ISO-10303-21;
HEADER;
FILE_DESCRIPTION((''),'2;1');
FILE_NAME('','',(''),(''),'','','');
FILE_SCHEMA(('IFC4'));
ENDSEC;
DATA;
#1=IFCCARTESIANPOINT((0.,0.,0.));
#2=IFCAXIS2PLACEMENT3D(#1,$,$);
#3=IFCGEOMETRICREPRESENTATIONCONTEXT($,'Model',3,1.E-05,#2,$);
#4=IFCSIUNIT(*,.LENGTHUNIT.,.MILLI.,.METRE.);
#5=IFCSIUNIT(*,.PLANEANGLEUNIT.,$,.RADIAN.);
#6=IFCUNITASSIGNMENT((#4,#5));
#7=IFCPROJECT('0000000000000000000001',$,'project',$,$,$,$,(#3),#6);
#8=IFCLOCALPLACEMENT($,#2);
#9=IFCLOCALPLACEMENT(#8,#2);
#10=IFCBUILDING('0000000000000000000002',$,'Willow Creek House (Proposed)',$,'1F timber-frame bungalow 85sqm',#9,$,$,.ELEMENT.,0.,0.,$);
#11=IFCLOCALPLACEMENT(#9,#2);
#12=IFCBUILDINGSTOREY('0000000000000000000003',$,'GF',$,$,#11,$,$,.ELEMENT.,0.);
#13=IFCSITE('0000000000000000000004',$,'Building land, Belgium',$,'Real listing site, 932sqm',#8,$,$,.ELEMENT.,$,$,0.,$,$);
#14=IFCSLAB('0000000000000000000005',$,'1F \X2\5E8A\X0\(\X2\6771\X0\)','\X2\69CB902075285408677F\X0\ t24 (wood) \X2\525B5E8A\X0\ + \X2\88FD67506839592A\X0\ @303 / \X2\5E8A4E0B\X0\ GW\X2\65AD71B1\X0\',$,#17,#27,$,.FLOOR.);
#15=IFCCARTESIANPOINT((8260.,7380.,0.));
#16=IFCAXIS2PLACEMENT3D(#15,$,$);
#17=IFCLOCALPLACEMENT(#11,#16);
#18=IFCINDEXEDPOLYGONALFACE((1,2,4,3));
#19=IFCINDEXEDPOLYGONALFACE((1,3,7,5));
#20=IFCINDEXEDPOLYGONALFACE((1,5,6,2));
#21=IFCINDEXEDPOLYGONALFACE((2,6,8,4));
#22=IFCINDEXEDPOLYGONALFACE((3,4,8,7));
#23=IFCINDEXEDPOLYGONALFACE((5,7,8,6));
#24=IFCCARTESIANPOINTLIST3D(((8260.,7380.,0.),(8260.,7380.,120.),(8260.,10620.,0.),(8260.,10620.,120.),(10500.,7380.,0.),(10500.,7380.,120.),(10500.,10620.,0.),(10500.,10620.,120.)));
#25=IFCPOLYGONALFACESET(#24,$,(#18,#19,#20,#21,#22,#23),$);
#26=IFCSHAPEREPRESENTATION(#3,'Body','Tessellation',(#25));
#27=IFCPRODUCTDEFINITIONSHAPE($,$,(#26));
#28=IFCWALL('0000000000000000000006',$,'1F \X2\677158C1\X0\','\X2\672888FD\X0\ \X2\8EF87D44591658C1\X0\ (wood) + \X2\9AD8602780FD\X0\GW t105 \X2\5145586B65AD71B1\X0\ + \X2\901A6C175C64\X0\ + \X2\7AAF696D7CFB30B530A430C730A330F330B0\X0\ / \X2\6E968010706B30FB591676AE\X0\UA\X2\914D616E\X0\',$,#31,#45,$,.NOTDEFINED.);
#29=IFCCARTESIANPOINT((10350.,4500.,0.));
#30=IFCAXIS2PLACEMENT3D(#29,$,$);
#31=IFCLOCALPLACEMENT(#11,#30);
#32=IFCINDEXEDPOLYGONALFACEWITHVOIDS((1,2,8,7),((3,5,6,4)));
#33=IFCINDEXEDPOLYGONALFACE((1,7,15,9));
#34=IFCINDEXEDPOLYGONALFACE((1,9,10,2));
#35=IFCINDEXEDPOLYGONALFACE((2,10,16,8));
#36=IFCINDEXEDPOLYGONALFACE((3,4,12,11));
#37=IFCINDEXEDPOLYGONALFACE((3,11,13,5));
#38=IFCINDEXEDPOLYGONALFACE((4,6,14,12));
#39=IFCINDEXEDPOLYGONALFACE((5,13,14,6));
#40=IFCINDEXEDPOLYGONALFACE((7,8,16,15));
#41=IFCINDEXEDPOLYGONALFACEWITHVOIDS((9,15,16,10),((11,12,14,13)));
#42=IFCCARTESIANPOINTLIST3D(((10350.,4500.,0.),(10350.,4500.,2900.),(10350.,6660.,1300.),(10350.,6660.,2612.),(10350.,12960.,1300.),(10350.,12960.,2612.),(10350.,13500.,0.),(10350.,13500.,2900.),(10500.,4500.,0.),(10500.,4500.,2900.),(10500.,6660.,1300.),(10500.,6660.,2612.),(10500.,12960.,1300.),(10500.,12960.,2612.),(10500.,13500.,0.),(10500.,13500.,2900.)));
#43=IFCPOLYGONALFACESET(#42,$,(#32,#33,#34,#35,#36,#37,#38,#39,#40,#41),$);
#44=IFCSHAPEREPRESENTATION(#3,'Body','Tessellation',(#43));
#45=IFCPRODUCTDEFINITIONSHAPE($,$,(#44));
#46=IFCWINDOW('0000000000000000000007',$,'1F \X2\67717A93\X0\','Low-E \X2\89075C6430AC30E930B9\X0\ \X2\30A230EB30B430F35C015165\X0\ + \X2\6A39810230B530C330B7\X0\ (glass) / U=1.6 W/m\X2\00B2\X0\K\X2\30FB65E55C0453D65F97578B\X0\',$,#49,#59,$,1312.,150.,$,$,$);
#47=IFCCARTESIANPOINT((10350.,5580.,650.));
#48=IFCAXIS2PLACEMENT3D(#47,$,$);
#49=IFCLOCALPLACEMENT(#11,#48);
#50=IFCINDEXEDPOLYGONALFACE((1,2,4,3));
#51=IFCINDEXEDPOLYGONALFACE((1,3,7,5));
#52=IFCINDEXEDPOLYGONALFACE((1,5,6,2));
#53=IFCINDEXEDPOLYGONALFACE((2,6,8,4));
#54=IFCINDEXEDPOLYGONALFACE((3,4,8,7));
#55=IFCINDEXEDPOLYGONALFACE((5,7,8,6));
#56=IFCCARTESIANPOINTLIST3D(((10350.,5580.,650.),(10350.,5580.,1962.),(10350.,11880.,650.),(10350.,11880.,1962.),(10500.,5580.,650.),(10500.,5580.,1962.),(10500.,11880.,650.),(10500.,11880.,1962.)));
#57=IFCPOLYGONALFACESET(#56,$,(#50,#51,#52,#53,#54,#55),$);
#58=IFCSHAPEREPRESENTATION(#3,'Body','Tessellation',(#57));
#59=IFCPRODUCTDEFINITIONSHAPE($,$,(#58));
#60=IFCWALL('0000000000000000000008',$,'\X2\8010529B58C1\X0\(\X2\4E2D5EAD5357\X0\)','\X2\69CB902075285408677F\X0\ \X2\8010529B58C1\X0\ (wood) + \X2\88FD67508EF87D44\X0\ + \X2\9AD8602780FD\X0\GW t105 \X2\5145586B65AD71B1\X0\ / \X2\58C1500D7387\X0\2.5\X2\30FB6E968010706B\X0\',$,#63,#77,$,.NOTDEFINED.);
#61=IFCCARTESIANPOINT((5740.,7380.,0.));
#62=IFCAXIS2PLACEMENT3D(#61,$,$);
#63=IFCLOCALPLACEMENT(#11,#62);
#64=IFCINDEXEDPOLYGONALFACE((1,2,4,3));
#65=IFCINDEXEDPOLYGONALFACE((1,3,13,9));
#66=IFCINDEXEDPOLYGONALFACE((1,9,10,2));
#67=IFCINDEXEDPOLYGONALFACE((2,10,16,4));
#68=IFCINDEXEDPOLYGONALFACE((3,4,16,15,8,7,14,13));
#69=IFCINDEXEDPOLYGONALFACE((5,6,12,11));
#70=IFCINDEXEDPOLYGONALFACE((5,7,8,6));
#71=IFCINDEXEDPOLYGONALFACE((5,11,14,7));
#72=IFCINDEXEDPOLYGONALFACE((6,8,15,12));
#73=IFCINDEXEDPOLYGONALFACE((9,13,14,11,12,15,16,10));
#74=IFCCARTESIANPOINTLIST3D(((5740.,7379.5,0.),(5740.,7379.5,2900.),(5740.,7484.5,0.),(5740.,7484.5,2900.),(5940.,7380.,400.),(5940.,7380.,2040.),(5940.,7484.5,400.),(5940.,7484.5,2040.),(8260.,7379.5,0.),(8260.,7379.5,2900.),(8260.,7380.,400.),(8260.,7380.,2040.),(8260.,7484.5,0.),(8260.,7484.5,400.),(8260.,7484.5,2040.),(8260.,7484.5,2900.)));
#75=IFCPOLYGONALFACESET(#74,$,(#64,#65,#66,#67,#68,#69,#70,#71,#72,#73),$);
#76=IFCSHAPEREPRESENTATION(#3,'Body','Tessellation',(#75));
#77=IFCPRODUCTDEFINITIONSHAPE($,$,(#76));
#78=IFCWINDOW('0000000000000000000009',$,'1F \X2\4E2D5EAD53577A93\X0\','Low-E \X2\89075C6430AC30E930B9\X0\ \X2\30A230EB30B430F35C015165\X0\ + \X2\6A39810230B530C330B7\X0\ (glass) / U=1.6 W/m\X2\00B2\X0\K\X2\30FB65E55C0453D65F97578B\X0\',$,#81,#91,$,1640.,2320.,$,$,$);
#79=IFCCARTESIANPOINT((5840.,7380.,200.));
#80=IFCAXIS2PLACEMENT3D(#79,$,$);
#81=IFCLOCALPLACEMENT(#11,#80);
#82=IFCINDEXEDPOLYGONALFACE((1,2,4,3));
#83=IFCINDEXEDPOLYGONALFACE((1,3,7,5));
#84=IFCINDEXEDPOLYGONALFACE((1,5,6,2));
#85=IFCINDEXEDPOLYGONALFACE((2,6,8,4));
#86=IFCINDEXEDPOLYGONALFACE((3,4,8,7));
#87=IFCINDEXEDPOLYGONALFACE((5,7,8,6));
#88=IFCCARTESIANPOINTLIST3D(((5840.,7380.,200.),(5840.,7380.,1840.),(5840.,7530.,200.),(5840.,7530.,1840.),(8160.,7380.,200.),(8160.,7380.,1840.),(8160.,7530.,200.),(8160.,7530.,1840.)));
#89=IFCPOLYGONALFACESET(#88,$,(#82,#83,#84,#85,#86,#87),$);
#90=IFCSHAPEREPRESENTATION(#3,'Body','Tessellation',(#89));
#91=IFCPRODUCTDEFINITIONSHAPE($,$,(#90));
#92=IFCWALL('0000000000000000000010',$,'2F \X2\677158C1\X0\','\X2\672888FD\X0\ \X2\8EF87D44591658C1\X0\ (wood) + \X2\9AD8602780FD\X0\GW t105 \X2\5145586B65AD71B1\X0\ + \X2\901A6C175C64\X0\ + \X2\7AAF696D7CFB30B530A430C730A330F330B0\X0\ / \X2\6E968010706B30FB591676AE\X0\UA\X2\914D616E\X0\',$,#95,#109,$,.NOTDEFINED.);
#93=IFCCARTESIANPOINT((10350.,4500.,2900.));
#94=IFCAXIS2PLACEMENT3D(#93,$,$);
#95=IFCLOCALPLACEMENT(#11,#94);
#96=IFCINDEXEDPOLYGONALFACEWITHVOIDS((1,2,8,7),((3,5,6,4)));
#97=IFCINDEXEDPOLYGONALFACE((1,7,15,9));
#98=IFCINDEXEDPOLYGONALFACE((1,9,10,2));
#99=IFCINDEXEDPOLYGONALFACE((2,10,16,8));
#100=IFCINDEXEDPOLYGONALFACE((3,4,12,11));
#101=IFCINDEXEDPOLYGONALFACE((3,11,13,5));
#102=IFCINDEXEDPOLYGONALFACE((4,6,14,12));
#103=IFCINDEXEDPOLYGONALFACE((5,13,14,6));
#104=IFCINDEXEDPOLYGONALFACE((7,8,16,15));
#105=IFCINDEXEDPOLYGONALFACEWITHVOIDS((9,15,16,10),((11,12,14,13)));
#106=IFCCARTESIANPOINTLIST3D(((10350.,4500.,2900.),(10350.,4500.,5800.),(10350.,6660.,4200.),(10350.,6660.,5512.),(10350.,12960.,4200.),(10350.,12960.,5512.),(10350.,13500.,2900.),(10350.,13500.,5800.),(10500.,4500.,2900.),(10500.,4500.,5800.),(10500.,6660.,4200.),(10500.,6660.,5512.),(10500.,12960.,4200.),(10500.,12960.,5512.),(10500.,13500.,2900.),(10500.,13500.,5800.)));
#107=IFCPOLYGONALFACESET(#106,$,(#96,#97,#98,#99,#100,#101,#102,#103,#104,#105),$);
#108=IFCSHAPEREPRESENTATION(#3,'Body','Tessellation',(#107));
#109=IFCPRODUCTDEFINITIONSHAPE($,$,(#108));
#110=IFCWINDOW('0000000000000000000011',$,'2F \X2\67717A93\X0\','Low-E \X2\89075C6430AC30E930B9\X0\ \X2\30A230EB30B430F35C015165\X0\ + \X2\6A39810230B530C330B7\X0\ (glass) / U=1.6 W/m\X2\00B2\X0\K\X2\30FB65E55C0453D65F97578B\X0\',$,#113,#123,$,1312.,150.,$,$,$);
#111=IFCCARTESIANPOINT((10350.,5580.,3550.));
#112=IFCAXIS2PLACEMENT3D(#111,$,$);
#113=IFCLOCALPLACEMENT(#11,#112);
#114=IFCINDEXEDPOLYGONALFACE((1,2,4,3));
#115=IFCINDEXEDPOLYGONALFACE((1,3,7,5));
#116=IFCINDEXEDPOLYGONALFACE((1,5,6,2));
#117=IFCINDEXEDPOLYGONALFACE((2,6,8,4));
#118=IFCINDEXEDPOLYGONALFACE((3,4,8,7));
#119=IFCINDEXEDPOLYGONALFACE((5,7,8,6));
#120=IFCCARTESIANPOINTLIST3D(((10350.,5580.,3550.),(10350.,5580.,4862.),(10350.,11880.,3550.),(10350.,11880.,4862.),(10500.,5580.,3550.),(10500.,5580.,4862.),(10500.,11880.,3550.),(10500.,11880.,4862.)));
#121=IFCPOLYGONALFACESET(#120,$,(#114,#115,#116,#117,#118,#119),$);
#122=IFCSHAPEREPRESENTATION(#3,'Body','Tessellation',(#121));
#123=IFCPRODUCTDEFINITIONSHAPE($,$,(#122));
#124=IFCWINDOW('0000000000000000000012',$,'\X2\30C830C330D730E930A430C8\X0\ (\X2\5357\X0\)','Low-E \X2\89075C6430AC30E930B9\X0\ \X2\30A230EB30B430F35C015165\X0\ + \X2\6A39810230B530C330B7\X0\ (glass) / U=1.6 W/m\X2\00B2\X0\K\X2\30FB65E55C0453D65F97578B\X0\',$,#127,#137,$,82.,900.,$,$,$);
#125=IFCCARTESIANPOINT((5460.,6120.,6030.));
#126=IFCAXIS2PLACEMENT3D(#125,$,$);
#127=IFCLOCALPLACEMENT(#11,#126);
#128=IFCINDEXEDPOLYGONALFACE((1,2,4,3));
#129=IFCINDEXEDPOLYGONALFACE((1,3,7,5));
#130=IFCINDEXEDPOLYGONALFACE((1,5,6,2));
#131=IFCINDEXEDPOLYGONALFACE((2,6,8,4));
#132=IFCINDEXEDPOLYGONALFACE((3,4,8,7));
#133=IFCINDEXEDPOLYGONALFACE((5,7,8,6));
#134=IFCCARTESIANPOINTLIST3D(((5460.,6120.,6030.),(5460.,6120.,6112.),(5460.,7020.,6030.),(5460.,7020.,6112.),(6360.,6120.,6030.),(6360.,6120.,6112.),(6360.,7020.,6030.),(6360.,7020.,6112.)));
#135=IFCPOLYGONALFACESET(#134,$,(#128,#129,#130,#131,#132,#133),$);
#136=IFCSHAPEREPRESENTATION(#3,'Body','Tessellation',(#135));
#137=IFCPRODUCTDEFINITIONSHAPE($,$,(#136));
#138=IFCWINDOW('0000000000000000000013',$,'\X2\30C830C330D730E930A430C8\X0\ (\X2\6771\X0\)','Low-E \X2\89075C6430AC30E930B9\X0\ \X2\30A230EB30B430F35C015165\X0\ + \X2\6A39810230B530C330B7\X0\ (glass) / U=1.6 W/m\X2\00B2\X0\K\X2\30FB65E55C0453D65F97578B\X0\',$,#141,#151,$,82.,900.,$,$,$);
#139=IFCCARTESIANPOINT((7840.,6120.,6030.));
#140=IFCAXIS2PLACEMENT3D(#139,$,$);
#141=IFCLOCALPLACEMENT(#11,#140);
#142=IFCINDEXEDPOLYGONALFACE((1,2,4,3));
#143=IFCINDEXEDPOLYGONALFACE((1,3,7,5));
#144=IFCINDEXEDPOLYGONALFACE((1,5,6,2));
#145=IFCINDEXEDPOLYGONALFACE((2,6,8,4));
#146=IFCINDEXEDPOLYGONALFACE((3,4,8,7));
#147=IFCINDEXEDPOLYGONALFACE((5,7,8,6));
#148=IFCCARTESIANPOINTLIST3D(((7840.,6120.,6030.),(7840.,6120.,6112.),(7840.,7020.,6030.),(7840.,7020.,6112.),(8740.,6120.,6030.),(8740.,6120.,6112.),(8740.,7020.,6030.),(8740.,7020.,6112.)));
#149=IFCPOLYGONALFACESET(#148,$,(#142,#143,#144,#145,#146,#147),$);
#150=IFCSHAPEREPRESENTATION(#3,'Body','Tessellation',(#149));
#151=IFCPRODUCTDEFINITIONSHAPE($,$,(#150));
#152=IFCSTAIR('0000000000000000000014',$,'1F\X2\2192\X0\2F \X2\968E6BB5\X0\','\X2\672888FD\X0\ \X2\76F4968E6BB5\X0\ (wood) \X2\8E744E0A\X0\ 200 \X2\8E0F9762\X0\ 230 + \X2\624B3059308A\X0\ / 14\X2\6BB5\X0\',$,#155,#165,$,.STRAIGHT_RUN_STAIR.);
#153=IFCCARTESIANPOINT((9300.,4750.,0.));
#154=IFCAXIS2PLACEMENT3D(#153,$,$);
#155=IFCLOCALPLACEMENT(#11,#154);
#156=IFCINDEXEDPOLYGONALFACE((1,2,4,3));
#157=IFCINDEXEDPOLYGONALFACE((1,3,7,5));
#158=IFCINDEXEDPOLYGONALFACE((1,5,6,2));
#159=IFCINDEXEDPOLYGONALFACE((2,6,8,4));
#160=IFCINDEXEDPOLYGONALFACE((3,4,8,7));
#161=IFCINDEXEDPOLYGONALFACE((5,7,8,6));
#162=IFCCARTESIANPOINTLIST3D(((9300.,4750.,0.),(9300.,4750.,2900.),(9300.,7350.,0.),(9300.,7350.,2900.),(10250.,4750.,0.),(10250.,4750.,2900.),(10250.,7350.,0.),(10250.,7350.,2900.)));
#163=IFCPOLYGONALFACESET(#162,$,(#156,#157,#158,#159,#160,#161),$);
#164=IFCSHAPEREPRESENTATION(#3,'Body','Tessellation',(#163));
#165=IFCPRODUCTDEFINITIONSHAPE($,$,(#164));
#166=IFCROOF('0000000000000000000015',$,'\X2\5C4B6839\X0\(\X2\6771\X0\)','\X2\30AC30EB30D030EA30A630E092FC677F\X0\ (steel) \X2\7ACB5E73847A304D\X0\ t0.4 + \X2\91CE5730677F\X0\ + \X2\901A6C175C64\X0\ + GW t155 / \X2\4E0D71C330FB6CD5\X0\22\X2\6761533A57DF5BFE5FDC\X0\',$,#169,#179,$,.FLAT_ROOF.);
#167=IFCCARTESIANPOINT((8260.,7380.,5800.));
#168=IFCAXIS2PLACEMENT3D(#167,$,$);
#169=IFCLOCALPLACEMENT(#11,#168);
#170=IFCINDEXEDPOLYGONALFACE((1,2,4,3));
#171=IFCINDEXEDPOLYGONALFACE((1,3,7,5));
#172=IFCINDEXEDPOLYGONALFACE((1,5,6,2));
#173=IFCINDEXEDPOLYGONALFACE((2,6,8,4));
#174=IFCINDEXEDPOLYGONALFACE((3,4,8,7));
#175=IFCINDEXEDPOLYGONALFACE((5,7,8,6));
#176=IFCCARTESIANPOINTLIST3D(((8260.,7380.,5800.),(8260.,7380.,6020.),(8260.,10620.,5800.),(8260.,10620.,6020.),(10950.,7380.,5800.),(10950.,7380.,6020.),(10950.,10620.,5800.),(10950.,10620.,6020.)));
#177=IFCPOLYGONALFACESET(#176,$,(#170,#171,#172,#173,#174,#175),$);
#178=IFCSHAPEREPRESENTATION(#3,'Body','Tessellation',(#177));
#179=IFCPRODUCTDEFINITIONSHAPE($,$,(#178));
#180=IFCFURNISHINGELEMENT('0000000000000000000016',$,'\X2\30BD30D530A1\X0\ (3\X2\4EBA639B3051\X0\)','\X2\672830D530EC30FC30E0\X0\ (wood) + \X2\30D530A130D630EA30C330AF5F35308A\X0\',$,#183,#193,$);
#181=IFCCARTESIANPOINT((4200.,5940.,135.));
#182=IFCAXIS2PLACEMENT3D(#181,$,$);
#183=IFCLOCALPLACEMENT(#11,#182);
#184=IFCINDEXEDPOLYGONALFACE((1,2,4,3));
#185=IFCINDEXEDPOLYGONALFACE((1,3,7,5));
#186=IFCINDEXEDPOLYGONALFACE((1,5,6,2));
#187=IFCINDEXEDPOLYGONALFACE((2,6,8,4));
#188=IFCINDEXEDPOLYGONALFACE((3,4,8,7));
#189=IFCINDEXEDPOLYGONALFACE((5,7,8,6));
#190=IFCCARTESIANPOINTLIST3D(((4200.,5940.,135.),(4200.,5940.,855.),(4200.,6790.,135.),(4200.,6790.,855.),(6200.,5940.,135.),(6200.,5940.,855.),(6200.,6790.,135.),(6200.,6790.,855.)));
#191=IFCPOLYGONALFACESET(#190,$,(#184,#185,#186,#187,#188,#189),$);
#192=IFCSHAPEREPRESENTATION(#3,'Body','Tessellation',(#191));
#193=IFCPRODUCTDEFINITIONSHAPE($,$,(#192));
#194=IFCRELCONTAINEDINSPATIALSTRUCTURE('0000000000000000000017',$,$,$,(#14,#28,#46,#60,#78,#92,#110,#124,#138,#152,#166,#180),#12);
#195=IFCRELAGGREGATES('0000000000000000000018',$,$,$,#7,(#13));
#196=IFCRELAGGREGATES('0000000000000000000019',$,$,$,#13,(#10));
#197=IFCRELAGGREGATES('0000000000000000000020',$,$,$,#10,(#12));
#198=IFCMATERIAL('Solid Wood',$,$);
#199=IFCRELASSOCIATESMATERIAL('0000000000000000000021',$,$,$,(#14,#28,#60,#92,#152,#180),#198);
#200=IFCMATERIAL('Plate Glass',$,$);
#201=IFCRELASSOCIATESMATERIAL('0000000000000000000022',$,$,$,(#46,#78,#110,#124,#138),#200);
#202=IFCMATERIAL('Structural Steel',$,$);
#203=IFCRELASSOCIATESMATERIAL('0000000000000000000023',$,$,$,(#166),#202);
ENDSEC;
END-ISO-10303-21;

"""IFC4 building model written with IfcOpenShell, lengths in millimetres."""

from ifc_helpers import new_model, si_unit, frame, frame_2d, origin, place, context, project, spatial, rectangle, extrude, material, element, fill, save


model = new_model("IFC4")

# Units and contexts
model_context = context("Model", 3, precision=1e-05, world=origin())
ifc_project = project(units=[si_unit("LENGTHUNIT", "METRE", prefix="MILLI"), si_unit("PLANEANGLEUNIT", "RADIAN")], contexts=[model_context])

# Site, building, storey
site_placement = place(None, origin())
site = spatial("IfcSite", under=ifc_project, at=site_placement, Name="Building land, Belgium", ObjectType="Real listing site, 932sqm", CompositionType="ELEMENT", RefElevation=0.0)
building_placement = place(site_placement, origin())
building = spatial("IfcBuilding", under=site, at=building_placement, Name="Willow Creek House (Proposed)", ObjectType="1F timber-frame bungalow 85sqm", CompositionType="ELEMENT", ElevationOfRefHeight=0.0, ElevationOfTerrain=0.0)
storey_placement = place(building_placement, origin())
storey = spatial("IfcBuildingStorey", under=building, at=storey_placement, Name="GF", CompositionType="ELEMENT", Elevation=0.0)

# Slab
ifc_material_1 = material(Name="Solid Wood")
slab_placement = place(storey_placement, frame((8260.0, 7380.0, 0.0)))
element("IfcSlab", 1, at=slab_placement, inside=storey, material=ifc_material_1, Name="1F 床(東)", Description="構造用合板 t24 (wood) 剛床 + 製材根太 @303 / 床下 GW断熱", PredefinedType="FLOOR", context=model_context, shape_type="SweptSolid", body=[
    extrude(rectangle(XDim=2240.0, YDim=3240.0, at=frame_2d((1120.0, 1620.0))), frame((8260.0, 7380.0, 0.0)), (0.0, 0.0, 1.0), 120.0),
])

# Walls, openings, windows
wall_1_placement = place(storey_placement, frame((10350.0, 4500.0, 0.0)))
wall_1 = element("IfcWall", 2, at=wall_1_placement, inside=storey, material=ifc_material_1, Name="1F 東壁", Description="木製 軸組外壁 (wood) + 高性能GW t105 充填断熱 + 通気層 + 窯業系サイディング / 準耐火・外皮UA配慮", PredefinedType="NOTDEFINED", context=model_context, shape_type="SweptSolid", body=[
    extrude(rectangle(XDim=150.0, YDim=9000.0, at=frame_2d((75.0, 4500.0))), frame((10350.0, 4500.0, 0.0)), (0.0, 0.0, 1.0), 2900.0),
])
opening_1_placement = place(storey_placement, frame((10350.0, 5580.0, 650.0)))
opening_1 = element("IfcOpeningElement", 3, at=opening_1_placement, cuts=wall_1, PredefinedType="NOTDEFINED", context=model_context, shape_type="SweptSolid", body=[
    extrude(rectangle(XDim=150.0, YDim=6300.0, at=frame_2d((75.0, 3150.0))), frame((10350.0, 5580.0, 650.0)), (0.0, 0.0, 1.0), 1312.0),
])
ifc_material_2 = material(Name="Plate Glass")
window_1_placement = place(storey_placement, frame((10350.0, 5580.0, 650.0)))
window_1 = element("IfcWindow", 4, at=window_1_placement, inside=storey, material=ifc_material_2, Name="1F 東窓", Description="Low-E 複層ガラス アルゴン封入 + 樹脂サッシ (glass) / U=1.6 W/m²K・日射取得型", OverallHeight=1312.0, OverallWidth=150.0, context=model_context, shape_type="SweptSolid", body=[
    extrude(rectangle(XDim=150.0, YDim=6300.0, at=frame_2d((75.0, 3150.0))), frame((10350.0, 5580.0, 650.0)), (0.0, 0.0, 1.0), 1312.0),
])
fill(opening_1, window_1)
wall_2_placement = place(storey_placement, frame((5740.0, 7380.0, 0.0)))
wall_2 = element("IfcWall", 5, at=wall_2_placement, inside=storey, material=ifc_material_1, Name="耐力壁(中庭南)", Description="構造用合板 耐力壁 (wood) + 製材軸組 + 高性能GW t105 充填断熱 / 壁倍率2.5・準耐火", PredefinedType="NOTDEFINED", context=model_context, shape_type="SweptSolid", body=[
    extrude(rectangle(XDim=2520.0, YDim=105.0, at=frame_2d((1260.0, 52.0))), frame((5740.0, 7380.0, 0.0)), (0.0, 0.0, 1.0), 2900.0),
])
opening_2_placement = place(storey_placement, frame((5840.0, 7380.0, 200.0)))
opening_2 = element("IfcOpeningElement", 6, at=opening_2_placement, cuts=wall_2, PredefinedType="NOTDEFINED", context=model_context, shape_type="SweptSolid", body=[
    extrude(rectangle(XDim=2320.0, YDim=150.0, at=frame_2d((1160.0, 75.0))), frame((5840.0, 7380.0, 200.0)), (0.0, 0.0, 1.0), 1640.0),
])
window_2_placement = place(storey_placement, frame((5840.0, 7380.0, 200.0)))
window_2 = element("IfcWindow", 7, at=window_2_placement, inside=storey, material=ifc_material_2, Name="1F 中庭南窓", Description="Low-E 複層ガラス アルゴン封入 + 樹脂サッシ (glass) / U=1.6 W/m²K・日射取得型", OverallHeight=1640.0, OverallWidth=2320.0, context=model_context, shape_type="SweptSolid", body=[
    extrude(rectangle(XDim=2320.0, YDim=150.0, at=frame_2d((1160.0, 75.0))), frame((5840.0, 7380.0, 200.0)), (0.0, 0.0, 1.0), 1640.0),
])
fill(opening_2, window_2)

# Wall, opening, window
wall_3_placement = place(storey_placement, frame((10350.0, 4500.0, 2900.0)))
wall_3 = element("IfcWall", 8, at=wall_3_placement, inside=storey, material=ifc_material_1, Name="2F 東壁", Description="木製 軸組外壁 (wood) + 高性能GW t105 充填断熱 + 通気層 + 窯業系サイディング / 準耐火・外皮UA配慮", PredefinedType="NOTDEFINED", context=model_context, shape_type="SweptSolid", body=[
    extrude(rectangle(XDim=150.0, YDim=9000.0, at=frame_2d((75.0, 4500.0))), frame((10350.0, 4500.0, 2900.0)), (0.0, 0.0, 1.0), 2900.0),
])
opening_3_placement = place(storey_placement, frame((10350.0, 5580.0, 3550.0)))
opening_3 = element("IfcOpeningElement", 9, at=opening_3_placement, cuts=wall_3, PredefinedType="NOTDEFINED", context=model_context, shape_type="SweptSolid", body=[
    extrude(rectangle(XDim=150.0, YDim=6300.0, at=frame_2d((75.0, 3150.0))), frame((10350.0, 5580.0, 3550.0)), (0.0, 0.0, 1.0), 1312.0),
])
window_3_placement = place(storey_placement, frame((10350.0, 5580.0, 3550.0)))
window_3 = element("IfcWindow", 10, at=window_3_placement, inside=storey, material=ifc_material_2, Name="2F 東窓", Description="Low-E 複層ガラス アルゴン封入 + 樹脂サッシ (glass) / U=1.6 W/m²K・日射取得型", OverallHeight=1312.0, OverallWidth=150.0, context=model_context, shape_type="SweptSolid", body=[
    extrude(rectangle(XDim=150.0, YDim=6300.0, at=frame_2d((75.0, 3150.0))), frame((10350.0, 5580.0, 3550.0)), (0.0, 0.0, 1.0), 1312.0),
])
fill(opening_3, window_3)

# Windows
window_4_placement = place(storey_placement, frame((5460.0, 6120.0, 6030.0)))
element("IfcWindow", 11, at=window_4_placement, inside=storey, material=ifc_material_2, Name="トップライト (南)", Description="Low-E 複層ガラス アルゴン封入 + 樹脂サッシ (glass) / U=1.6 W/m²K・日射取得型", OverallHeight=82.0, OverallWidth=900.0, context=model_context, shape_type="SweptSolid", body=[
    extrude(rectangle(XDim=900.0, YDim=900.0, at=frame_2d((450.0, 450.0))), frame((5460.0, 6120.0, 6030.0)), (0.0, 0.0, 1.0), 82.0),
])
window_5_placement = place(storey_placement, frame((7840.0, 6120.0, 6030.0)))
element("IfcWindow", 12, at=window_5_placement, inside=storey, material=ifc_material_2, Name="トップライト (東)", Description="Low-E 複層ガラス アルゴン封入 + 樹脂サッシ (glass) / U=1.6 W/m²K・日射取得型", OverallHeight=82.0, OverallWidth=900.0, context=model_context, shape_type="SweptSolid", body=[
    extrude(rectangle(XDim=900.0, YDim=900.0, at=frame_2d((450.0, 450.0))), frame((7840.0, 6120.0, 6030.0)), (0.0, 0.0, 1.0), 82.0),
])

# Stair
stair_placement = place(storey_placement, frame((9300.0, 4750.0, 0.0)))
element("IfcStair", 13, at=stair_placement, inside=storey, material=ifc_material_1, Name="1F→2F 階段", Description="木製 直階段 (wood) 蹴上 200 踏面 230 + 手すり / 14段", PredefinedType="STRAIGHT_RUN_STAIR", context=model_context, shape_type="SweptSolid", body=[
    extrude(rectangle(XDim=950.0, YDim=2600.0, at=frame_2d((475.0, 1300.0))), frame((9300.0, 4750.0, 0.0)), (0.0, 0.0, 1.0), 2900.0),
])

# Roof
ifc_material_3 = material(Name="Structural Steel")
roof_placement = place(storey_placement, frame((8260.0, 7380.0, 5800.0)))
element("IfcRoof", 14, at=roof_placement, inside=storey, material=ifc_material_3, Name="屋根(東)", Description="ガルバリウム鋼板 (steel) 立平葺き t0.4 + 野地板 + 通気層 + GW t155 / 不燃・法22条区域対応", PredefinedType="FLAT_ROOF", context=model_context, shape_type="SweptSolid", body=[
    extrude(rectangle(XDim=2690.0, YDim=3240.0, at=frame_2d((1345.0, 1620.0))), frame((8260.0, 7380.0, 5800.0)), (0.0, 0.0, 1.0), 220.0),
])

# Furnishing element
furnishing_1_placement = place(storey_placement, frame((4200.0, 5940.0, 135.0)))
element("IfcFurnishingElement", 15, at=furnishing_1_placement, inside=storey, material=ifc_material_1, Name="ソファ (3人掛け)", Description="木フレーム (wood) + ファブリック張り", context=model_context, shape_type="SweptSolid", body=[
    extrude(rectangle(XDim=2000.0, YDim=850.0, at=frame_2d((1000.0, 425.0))), frame((4200.0, 5940.0, 135.0)), (0.0, 0.0, 1.0), 720.0),
])

save(model, "model.ifc")
